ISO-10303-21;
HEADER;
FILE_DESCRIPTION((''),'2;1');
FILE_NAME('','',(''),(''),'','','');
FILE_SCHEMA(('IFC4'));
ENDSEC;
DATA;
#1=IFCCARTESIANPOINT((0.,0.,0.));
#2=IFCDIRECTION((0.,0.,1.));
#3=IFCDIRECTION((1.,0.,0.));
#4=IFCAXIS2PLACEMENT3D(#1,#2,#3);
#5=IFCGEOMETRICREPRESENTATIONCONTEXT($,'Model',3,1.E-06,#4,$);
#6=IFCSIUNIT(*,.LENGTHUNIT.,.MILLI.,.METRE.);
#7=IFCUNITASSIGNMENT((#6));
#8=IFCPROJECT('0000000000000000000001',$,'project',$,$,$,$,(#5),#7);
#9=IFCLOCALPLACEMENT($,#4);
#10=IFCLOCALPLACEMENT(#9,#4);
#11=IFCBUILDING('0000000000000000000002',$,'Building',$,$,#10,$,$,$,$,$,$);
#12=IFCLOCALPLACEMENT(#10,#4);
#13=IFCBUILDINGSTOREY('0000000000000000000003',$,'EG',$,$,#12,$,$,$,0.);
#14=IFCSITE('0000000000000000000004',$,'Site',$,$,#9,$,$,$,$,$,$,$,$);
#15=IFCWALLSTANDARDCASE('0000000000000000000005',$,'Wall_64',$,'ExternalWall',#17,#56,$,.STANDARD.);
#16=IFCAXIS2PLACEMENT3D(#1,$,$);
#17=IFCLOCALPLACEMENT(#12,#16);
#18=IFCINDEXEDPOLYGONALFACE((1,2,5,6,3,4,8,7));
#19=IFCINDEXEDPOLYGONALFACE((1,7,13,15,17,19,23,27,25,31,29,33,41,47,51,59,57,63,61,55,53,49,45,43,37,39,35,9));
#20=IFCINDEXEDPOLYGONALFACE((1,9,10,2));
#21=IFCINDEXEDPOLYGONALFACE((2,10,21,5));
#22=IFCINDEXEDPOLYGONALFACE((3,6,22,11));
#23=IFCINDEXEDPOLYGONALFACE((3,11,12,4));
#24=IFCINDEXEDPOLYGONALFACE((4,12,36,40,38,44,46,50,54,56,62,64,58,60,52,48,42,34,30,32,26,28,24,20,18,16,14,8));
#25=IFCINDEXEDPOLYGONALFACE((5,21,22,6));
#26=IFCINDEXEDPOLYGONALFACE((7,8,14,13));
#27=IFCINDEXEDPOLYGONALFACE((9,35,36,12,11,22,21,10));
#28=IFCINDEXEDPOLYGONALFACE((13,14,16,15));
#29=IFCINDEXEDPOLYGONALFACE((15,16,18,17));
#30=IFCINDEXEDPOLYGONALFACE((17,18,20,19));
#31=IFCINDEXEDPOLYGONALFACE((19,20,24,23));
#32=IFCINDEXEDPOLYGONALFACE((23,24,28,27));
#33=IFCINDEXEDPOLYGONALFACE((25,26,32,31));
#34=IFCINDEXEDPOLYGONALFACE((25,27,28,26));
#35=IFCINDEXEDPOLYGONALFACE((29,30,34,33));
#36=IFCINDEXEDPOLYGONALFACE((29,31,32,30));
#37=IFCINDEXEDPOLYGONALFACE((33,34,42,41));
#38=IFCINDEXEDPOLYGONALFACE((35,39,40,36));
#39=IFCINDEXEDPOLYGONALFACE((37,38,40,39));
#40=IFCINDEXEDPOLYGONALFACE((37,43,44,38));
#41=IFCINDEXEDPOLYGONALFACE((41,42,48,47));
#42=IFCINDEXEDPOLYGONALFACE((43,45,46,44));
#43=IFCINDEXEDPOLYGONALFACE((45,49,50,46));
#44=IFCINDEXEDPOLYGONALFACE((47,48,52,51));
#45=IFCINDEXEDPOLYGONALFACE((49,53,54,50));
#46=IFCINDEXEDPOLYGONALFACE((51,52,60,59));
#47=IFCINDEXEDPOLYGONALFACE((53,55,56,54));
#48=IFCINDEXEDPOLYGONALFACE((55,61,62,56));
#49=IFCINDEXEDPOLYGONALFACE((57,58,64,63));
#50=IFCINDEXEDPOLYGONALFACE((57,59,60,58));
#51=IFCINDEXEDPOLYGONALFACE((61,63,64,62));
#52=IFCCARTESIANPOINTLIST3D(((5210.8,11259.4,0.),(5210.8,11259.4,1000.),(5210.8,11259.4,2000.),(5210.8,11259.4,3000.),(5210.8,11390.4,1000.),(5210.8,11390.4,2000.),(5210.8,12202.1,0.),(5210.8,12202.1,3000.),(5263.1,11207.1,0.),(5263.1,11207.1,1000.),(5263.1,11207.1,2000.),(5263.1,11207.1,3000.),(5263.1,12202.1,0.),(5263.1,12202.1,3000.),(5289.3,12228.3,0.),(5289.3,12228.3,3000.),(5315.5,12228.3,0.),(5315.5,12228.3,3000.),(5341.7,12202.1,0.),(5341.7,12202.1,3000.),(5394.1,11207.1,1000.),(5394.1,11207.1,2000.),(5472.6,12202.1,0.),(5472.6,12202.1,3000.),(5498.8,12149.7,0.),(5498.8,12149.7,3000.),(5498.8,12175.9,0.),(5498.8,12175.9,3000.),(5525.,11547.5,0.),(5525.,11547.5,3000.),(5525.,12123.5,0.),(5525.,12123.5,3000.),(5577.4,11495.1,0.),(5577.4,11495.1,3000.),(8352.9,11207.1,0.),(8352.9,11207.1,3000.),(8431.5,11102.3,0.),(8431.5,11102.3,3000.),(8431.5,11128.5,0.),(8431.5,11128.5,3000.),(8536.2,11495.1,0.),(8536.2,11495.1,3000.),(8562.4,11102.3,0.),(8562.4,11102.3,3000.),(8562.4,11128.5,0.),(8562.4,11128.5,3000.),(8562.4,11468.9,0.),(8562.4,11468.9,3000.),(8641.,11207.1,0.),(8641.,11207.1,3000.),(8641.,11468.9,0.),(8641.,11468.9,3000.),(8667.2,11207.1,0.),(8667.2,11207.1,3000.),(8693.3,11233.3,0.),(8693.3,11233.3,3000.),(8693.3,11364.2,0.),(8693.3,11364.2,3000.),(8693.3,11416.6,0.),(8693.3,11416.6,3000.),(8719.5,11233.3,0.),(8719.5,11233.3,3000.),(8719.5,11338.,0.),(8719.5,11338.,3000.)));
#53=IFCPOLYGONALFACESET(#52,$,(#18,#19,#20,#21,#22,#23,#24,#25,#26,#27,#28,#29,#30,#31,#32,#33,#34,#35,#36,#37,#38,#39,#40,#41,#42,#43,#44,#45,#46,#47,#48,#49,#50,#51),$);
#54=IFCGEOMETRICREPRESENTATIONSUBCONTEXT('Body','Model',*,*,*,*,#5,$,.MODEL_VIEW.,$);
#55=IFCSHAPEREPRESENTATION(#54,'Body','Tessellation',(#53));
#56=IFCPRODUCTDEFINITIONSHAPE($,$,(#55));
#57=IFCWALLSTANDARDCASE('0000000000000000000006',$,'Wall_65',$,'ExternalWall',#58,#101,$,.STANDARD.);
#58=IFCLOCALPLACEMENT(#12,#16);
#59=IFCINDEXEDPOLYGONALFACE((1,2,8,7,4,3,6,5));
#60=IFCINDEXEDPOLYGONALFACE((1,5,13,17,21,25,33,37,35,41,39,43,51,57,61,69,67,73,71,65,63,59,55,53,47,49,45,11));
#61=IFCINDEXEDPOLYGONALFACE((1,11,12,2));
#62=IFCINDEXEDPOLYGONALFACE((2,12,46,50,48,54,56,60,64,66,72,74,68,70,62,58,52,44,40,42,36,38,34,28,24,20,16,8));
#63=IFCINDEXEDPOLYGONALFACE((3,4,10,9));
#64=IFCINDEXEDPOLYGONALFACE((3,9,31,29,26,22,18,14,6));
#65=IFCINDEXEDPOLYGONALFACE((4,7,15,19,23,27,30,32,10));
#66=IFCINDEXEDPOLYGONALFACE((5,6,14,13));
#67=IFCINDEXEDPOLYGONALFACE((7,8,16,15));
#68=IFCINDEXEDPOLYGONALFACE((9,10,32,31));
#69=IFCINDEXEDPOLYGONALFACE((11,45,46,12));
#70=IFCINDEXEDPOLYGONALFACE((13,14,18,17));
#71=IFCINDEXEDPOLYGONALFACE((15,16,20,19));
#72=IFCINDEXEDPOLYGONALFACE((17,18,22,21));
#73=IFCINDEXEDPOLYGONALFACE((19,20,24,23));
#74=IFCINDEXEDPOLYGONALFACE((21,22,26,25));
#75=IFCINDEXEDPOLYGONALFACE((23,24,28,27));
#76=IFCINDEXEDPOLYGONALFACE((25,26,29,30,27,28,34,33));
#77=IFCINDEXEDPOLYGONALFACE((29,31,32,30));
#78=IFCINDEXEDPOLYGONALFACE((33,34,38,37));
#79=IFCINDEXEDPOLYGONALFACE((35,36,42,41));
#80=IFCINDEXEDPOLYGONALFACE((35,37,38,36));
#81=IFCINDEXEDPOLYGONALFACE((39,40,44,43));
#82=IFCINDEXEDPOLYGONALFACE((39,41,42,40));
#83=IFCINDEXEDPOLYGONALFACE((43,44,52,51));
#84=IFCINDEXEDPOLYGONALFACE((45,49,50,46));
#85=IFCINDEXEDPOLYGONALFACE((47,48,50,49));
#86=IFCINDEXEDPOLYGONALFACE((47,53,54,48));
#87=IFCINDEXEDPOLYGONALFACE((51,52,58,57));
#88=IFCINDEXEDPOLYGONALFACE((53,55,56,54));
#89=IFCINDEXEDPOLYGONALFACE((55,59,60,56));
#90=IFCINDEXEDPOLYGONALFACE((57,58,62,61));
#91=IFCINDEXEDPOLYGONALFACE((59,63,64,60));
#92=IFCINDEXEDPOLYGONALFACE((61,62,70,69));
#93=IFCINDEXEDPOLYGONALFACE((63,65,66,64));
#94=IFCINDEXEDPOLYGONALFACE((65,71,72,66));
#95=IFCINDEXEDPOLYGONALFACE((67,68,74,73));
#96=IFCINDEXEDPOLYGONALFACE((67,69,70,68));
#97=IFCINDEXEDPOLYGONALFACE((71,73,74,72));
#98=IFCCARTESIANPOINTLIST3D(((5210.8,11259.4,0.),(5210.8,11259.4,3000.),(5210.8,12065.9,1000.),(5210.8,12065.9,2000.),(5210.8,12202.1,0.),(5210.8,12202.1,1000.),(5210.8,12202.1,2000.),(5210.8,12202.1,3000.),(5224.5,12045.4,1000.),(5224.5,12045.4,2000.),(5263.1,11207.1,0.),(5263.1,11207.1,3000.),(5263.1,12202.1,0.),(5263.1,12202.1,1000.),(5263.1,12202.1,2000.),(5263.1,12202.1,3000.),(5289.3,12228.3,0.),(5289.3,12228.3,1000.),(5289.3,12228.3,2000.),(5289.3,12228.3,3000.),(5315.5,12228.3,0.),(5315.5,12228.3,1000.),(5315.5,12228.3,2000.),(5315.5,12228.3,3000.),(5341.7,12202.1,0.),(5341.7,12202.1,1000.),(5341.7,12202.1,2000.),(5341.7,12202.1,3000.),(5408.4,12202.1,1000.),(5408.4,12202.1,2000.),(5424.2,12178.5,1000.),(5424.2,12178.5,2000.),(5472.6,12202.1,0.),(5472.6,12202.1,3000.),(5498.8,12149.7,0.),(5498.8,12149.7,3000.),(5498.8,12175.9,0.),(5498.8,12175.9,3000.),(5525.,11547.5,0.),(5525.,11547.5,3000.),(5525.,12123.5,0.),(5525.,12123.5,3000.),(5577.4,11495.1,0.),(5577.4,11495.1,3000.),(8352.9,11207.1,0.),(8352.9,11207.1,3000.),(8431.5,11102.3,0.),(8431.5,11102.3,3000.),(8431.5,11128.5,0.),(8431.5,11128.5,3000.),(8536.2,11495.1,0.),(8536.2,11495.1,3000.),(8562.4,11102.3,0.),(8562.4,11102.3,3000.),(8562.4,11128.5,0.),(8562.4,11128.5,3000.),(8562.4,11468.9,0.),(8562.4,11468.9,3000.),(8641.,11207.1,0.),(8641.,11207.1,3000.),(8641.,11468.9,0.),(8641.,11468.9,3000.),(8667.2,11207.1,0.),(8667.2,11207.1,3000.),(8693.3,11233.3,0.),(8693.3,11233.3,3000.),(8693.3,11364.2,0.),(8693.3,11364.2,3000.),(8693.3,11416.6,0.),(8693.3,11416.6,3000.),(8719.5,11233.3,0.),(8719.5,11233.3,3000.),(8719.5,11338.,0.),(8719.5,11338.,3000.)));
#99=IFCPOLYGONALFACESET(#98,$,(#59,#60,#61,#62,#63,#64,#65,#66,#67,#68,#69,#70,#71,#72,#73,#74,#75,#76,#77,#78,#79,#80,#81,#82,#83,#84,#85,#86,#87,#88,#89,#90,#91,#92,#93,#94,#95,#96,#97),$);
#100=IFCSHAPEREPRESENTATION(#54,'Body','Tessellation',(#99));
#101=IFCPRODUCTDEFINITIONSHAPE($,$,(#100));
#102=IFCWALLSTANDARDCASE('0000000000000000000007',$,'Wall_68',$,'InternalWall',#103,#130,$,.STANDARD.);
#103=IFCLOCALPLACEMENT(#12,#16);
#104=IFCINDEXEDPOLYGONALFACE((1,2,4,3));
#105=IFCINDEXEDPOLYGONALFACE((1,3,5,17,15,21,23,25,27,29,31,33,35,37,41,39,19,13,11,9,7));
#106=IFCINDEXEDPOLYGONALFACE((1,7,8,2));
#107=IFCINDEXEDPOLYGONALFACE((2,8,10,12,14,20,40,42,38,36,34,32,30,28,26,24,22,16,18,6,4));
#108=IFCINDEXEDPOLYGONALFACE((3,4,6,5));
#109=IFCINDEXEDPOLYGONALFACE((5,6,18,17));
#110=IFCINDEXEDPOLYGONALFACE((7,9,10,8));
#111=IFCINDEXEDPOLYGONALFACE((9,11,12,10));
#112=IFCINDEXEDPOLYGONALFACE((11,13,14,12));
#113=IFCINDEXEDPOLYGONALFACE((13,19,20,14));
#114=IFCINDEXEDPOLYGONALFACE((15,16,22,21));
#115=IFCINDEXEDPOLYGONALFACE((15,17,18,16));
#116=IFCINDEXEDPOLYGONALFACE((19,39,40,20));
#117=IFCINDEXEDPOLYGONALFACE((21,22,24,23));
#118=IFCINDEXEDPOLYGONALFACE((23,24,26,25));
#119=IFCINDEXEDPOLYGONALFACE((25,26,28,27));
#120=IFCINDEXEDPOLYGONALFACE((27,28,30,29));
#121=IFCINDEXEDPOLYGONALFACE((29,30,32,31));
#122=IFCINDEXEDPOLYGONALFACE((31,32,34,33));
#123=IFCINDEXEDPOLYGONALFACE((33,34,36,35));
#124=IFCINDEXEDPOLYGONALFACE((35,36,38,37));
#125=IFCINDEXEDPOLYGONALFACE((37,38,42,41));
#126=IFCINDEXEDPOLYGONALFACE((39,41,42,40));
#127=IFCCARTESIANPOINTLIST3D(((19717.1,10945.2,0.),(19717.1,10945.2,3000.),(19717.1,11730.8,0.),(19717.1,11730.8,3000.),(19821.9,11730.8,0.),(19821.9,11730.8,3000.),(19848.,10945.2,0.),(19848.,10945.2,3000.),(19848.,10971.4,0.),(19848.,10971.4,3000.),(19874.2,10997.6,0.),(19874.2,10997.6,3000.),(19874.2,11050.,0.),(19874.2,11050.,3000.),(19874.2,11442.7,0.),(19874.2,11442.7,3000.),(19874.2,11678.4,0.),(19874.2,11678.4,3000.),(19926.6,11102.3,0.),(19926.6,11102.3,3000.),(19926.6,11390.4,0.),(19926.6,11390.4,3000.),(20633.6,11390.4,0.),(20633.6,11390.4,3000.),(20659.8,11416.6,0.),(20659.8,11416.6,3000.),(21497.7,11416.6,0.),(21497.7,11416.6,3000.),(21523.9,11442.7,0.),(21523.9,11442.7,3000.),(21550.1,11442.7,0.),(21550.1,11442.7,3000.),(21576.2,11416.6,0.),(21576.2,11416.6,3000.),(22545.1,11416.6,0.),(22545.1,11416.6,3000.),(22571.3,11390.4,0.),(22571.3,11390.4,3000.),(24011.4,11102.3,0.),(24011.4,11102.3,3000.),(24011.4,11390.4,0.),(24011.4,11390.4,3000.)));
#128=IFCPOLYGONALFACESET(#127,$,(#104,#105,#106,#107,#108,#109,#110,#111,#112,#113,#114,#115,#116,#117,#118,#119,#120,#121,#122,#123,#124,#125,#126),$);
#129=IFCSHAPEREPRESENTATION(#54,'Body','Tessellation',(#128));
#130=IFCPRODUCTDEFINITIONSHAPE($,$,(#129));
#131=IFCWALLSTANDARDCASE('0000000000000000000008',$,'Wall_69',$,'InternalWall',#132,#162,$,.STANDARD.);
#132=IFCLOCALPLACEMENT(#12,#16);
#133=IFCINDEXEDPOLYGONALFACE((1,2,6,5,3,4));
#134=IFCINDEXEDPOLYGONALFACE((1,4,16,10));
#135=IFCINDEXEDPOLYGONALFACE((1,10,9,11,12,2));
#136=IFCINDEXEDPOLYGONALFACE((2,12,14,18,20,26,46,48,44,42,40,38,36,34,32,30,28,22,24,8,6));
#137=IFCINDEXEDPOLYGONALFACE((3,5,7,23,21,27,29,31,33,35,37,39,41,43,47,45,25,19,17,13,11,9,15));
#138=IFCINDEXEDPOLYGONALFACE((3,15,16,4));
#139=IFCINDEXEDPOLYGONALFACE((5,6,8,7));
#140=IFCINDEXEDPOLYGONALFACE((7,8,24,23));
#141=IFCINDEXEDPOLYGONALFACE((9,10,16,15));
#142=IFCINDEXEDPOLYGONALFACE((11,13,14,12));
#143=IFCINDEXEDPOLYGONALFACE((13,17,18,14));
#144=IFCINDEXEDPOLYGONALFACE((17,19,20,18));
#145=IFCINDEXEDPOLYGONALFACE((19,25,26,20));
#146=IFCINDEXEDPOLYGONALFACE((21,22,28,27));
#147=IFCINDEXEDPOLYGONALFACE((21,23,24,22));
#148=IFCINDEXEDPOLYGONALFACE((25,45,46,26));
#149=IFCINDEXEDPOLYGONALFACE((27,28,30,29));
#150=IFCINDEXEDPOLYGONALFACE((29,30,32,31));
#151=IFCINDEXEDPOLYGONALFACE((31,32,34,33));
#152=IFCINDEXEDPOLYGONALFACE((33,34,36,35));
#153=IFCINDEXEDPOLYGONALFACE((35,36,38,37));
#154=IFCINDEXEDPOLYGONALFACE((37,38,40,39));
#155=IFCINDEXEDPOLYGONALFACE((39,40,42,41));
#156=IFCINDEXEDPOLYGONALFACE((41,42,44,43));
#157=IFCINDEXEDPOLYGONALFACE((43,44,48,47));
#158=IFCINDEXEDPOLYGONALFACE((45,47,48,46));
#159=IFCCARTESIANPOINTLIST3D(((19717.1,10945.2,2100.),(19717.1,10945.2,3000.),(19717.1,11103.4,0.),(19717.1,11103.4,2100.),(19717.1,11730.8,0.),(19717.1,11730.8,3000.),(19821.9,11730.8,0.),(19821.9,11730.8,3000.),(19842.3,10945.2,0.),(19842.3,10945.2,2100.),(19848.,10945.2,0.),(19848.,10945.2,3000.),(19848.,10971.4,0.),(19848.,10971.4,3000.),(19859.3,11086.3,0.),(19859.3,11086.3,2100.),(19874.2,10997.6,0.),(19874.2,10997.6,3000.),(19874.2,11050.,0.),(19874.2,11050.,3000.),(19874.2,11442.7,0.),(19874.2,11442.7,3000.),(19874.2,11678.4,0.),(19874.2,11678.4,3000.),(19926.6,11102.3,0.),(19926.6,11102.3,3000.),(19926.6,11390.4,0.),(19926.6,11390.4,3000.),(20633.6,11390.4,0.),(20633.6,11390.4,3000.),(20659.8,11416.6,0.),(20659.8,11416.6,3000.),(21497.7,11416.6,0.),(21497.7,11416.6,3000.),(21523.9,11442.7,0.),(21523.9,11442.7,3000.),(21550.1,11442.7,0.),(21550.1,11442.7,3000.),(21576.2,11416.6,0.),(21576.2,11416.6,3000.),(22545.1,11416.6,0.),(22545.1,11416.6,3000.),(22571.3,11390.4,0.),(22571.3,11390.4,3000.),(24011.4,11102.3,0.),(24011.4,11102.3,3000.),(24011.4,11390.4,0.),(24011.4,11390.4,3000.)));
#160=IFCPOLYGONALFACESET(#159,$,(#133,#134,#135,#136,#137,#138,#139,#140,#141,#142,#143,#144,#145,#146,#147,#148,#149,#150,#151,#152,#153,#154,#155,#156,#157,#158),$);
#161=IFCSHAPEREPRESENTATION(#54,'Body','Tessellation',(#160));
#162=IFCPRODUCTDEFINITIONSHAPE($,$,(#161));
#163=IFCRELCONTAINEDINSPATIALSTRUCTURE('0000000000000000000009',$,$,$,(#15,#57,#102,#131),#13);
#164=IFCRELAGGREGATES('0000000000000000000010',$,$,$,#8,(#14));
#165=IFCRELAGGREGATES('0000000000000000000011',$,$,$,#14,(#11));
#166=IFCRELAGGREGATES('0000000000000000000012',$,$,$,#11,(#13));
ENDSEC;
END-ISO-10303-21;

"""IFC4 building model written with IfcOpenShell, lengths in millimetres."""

from ifc_helpers import new_model, si_unit, frame, origin_with_axes, place, context, subcontext, project, spatial, polyline, rectangle, outline, extrude, element, save


model = new_model("IFC4")

# Units and contexts
model_context = context("Model", 3, precision=1e-06, world=origin_with_axes())
body_context = subcontext(model_context, "Body", "Model", "MODEL_VIEW")
ifc_project = project(units=[si_unit("LENGTHUNIT", "METRE", prefix="MILLI")], contexts=[model_context])

# Site, building, storey
site_placement = place(None, origin_with_axes())
site = spatial("IfcSite", under=ifc_project, at=site_placement, Name="Site")
building_placement = place(site_placement, origin_with_axes())
building = spatial("IfcBuilding", under=site, at=building_placement, Name="Building")
storey_placement = place(building_placement, origin_with_axes())
storey = spatial("IfcBuildingStorey", under=building, at=storey_placement, Name="EG", Elevation=0.0)

# Walls, openings
wall_1_placement = place(storey_placement, origin_with_axes())
wall_1 = element("IfcWallStandardCase", 1, at=wall_1_placement, inside=storey, Name="Wall_64", ObjectType="ExternalWall", PredefinedType="STANDARD", context=body_context, shape_type="SweptSolid", body=[
    extrude(outline(polyline([(8431.5, 11102.3, 0.0), (8431.5, 11128.5, 0.0), (8352.9, 11207.1, 0.0), (5263.1, 11207.1, 0.0), (5210.8, 11259.4, 0.0), (5210.8, 12202.1, 0.0), (5263.1, 12202.1, 0.0), (5289.3, 12228.3, 0.0), (5315.5, 12228.3, 0.0), (5341.7, 12202.1, 0.0), (5472.6, 12202.1, 0.0), (5498.8, 12175.9, 0.0), (5498.8, 12149.7, 0.0), (5525.0, 12123.5, 0.0), (5525.0, 11547.5, 0.0), (5577.4, 11495.1, 0.0), (8536.2, 11495.1, 0.0), (8562.4, 11468.9, 0.0), (8641.0, 11468.9, 0.0), (8693.3, 11416.6, 0.0), (8693.3, 11364.2, 0.0), (8719.5, 11338.0, 0.0), (8719.5, 11233.3, 0.0), (8693.3, 11233.3, 0.0), (8667.2, 11207.1, 0.0), (8641.0, 11207.1, 0.0), (8562.4, 11128.5, 0.0), (8562.4, 11102.3, 0.0), (8431.5, 11102.3, 0.0)])), origin_with_axes(), (0.0, 0.0, 1.0), 3000.0),
])
opening_1_placement = place(wall_1_placement, origin_with_axes())
element("IfcOpeningElement", 2, at=opening_1_placement, inside=storey, cuts=wall_1, context=body_context, shape_type="SweptSolid", body=[
    extrude(rectangle(XDim=629.5, YDim=300.0), frame((5077.3, 11078.7, 1000.0), z_axis=(0.0, 0.0, 1.0), x_axis=(-0.707107, -0.707107, 0.0)), (0.0, 0.0, 1.0), 1000.0),
])
wall_2_placement = place(storey_placement, origin_with_axes())
wall_2 = element("IfcWallStandardCase", 3, at=wall_2_placement, inside=storey, Name="Wall_65", ObjectType="ExternalWall", PredefinedType="STANDARD", context=body_context, shape_type="SweptSolid", body=[
    extrude(outline(polyline([(8431.5, 11102.3, 0.0), (8431.5, 11128.5, 0.0), (8352.9, 11207.1, 0.0), (5263.1, 11207.1, 0.0), (5210.8, 11259.4, 0.0), (5210.8, 12202.1, 0.0), (5263.1, 12202.1, 0.0), (5289.3, 12228.3, 0.0), (5315.5, 12228.3, 0.0), (5341.7, 12202.1, 0.0), (5472.6, 12202.1, 0.0), (5498.8, 12175.9, 0.0), (5498.8, 12149.7, 0.0), (5525.0, 12123.5, 0.0), (5525.0, 11547.5, 0.0), (5577.4, 11495.1, 0.0), (8536.2, 11495.1, 0.0), (8562.4, 11468.9, 0.0), (8641.0, 11468.9, 0.0), (8693.3, 11416.6, 0.0), (8693.3, 11364.2, 0.0), (8719.5, 11338.0, 0.0), (8719.5, 11233.3, 0.0), (8693.3, 11233.3, 0.0), (8667.2, 11207.1, 0.0), (8641.0, 11207.1, 0.0), (8562.4, 11128.5, 0.0), (8562.4, 11102.3, 0.0), (8431.5, 11102.3, 0.0)])), origin_with_axes(), (0.0, 0.0, 1.0), 3000.0),
])
opening_2_placement = place(wall_2_placement, origin_with_axes())
element("IfcOpeningElement", 4, at=opening_2_placement, inside=storey, cuts=wall_2, context=body_context, shape_type="SweptSolid", body=[
    extrude(rectangle(XDim=2563.6, YDim=240.0), frame((4613.3, 13178.5, 1000.0), z_axis=(0.0, 0.0, 1.0), x_axis=(-0.5547, 0.83205, 0.0)), (0.0, 0.0, 1.0), 1000.0),
])

# Wall
wall_3_placement = place(storey_placement, origin_with_axes())
element("IfcWallStandardCase", 5, at=wall_3_placement, inside=storey, Name="Wall_68", ObjectType="InternalWall", PredefinedType="STANDARD", context=body_context, shape_type="SweptSolid", body=[
    extrude(outline(polyline([(19717.1, 10945.2, 0.0), (19717.1, 11730.8, 0.0), (19821.9, 11730.8, 0.0), (19874.2, 11678.4, 0.0), (19874.2, 11442.7, 0.0), (19926.6, 11390.4, 0.0), (20633.6, 11390.4, 0.0), (20659.8, 11416.6, 0.0), (21497.7, 11416.6, 0.0), (21523.9, 11442.7, 0.0), (21550.1, 11442.7, 0.0), (21576.2, 11416.6, 0.0), (22545.1, 11416.6, 0.0), (22571.3, 11390.4, 0.0), (24011.4, 11390.4, 0.0), (24011.4, 11102.3, 0.0), (19926.6, 11102.3, 0.0), (19874.2, 11050.0, 0.0), (19874.2, 10997.6, 0.0), (19848.0, 10971.4, 0.0), (19848.0, 10945.2, 0.0), (19717.1, 10945.2, 0.0)])), origin_with_axes(), (0.0, 0.0, 1.0), 3000.0),
])

# Wall, opening
wall_4_placement = place(storey_placement, origin_with_axes())
wall_4 = element("IfcWallStandardCase", 6, at=wall_4_placement, inside=storey, Name="Wall_69", ObjectType="InternalWall", PredefinedType="STANDARD", context=body_context, shape_type="SweptSolid", body=[
    extrude(outline(polyline([(19717.1, 10945.2, 0.0), (19717.1, 11730.8, 0.0), (19821.9, 11730.8, 0.0), (19874.2, 11678.4, 0.0), (19874.2, 11442.7, 0.0), (19926.6, 11390.4, 0.0), (20633.6, 11390.4, 0.0), (20659.8, 11416.6, 0.0), (21497.7, 11416.6, 0.0), (21523.9, 11442.7, 0.0), (21550.1, 11442.7, 0.0), (21576.2, 11416.6, 0.0), (22545.1, 11416.6, 0.0), (22571.3, 11390.4, 0.0), (24011.4, 11390.4, 0.0), (24011.4, 11102.3, 0.0), (19926.6, 11102.3, 0.0), (19874.2, 11050.0, 0.0), (19874.2, 10997.6, 0.0), (19848.0, 10971.4, 0.0), (19848.0, 10945.2, 0.0), (19717.1, 10945.2, 0.0)])), origin_with_axes(), (0.0, 0.0, 1.0), 3000.0),
])
opening_3_placement = place(wall_4_placement, origin_with_axes())
element("IfcOpeningElement", 7, at=opening_3_placement, inside=storey, cuts=wall_4, context=body_context, shape_type="SweptSolid", body=[
    extrude(rectangle(XDim=1171.0, YDim=240.0), frame((19670.4, 10519.3, 0.0), z_axis=(0.0, 0.0, 1.0), x_axis=(-0.119145, -0.992877, 0.0)), (0.0, 0.0, 1.0), 2100.0),
])

save(model, "model.ifc")
